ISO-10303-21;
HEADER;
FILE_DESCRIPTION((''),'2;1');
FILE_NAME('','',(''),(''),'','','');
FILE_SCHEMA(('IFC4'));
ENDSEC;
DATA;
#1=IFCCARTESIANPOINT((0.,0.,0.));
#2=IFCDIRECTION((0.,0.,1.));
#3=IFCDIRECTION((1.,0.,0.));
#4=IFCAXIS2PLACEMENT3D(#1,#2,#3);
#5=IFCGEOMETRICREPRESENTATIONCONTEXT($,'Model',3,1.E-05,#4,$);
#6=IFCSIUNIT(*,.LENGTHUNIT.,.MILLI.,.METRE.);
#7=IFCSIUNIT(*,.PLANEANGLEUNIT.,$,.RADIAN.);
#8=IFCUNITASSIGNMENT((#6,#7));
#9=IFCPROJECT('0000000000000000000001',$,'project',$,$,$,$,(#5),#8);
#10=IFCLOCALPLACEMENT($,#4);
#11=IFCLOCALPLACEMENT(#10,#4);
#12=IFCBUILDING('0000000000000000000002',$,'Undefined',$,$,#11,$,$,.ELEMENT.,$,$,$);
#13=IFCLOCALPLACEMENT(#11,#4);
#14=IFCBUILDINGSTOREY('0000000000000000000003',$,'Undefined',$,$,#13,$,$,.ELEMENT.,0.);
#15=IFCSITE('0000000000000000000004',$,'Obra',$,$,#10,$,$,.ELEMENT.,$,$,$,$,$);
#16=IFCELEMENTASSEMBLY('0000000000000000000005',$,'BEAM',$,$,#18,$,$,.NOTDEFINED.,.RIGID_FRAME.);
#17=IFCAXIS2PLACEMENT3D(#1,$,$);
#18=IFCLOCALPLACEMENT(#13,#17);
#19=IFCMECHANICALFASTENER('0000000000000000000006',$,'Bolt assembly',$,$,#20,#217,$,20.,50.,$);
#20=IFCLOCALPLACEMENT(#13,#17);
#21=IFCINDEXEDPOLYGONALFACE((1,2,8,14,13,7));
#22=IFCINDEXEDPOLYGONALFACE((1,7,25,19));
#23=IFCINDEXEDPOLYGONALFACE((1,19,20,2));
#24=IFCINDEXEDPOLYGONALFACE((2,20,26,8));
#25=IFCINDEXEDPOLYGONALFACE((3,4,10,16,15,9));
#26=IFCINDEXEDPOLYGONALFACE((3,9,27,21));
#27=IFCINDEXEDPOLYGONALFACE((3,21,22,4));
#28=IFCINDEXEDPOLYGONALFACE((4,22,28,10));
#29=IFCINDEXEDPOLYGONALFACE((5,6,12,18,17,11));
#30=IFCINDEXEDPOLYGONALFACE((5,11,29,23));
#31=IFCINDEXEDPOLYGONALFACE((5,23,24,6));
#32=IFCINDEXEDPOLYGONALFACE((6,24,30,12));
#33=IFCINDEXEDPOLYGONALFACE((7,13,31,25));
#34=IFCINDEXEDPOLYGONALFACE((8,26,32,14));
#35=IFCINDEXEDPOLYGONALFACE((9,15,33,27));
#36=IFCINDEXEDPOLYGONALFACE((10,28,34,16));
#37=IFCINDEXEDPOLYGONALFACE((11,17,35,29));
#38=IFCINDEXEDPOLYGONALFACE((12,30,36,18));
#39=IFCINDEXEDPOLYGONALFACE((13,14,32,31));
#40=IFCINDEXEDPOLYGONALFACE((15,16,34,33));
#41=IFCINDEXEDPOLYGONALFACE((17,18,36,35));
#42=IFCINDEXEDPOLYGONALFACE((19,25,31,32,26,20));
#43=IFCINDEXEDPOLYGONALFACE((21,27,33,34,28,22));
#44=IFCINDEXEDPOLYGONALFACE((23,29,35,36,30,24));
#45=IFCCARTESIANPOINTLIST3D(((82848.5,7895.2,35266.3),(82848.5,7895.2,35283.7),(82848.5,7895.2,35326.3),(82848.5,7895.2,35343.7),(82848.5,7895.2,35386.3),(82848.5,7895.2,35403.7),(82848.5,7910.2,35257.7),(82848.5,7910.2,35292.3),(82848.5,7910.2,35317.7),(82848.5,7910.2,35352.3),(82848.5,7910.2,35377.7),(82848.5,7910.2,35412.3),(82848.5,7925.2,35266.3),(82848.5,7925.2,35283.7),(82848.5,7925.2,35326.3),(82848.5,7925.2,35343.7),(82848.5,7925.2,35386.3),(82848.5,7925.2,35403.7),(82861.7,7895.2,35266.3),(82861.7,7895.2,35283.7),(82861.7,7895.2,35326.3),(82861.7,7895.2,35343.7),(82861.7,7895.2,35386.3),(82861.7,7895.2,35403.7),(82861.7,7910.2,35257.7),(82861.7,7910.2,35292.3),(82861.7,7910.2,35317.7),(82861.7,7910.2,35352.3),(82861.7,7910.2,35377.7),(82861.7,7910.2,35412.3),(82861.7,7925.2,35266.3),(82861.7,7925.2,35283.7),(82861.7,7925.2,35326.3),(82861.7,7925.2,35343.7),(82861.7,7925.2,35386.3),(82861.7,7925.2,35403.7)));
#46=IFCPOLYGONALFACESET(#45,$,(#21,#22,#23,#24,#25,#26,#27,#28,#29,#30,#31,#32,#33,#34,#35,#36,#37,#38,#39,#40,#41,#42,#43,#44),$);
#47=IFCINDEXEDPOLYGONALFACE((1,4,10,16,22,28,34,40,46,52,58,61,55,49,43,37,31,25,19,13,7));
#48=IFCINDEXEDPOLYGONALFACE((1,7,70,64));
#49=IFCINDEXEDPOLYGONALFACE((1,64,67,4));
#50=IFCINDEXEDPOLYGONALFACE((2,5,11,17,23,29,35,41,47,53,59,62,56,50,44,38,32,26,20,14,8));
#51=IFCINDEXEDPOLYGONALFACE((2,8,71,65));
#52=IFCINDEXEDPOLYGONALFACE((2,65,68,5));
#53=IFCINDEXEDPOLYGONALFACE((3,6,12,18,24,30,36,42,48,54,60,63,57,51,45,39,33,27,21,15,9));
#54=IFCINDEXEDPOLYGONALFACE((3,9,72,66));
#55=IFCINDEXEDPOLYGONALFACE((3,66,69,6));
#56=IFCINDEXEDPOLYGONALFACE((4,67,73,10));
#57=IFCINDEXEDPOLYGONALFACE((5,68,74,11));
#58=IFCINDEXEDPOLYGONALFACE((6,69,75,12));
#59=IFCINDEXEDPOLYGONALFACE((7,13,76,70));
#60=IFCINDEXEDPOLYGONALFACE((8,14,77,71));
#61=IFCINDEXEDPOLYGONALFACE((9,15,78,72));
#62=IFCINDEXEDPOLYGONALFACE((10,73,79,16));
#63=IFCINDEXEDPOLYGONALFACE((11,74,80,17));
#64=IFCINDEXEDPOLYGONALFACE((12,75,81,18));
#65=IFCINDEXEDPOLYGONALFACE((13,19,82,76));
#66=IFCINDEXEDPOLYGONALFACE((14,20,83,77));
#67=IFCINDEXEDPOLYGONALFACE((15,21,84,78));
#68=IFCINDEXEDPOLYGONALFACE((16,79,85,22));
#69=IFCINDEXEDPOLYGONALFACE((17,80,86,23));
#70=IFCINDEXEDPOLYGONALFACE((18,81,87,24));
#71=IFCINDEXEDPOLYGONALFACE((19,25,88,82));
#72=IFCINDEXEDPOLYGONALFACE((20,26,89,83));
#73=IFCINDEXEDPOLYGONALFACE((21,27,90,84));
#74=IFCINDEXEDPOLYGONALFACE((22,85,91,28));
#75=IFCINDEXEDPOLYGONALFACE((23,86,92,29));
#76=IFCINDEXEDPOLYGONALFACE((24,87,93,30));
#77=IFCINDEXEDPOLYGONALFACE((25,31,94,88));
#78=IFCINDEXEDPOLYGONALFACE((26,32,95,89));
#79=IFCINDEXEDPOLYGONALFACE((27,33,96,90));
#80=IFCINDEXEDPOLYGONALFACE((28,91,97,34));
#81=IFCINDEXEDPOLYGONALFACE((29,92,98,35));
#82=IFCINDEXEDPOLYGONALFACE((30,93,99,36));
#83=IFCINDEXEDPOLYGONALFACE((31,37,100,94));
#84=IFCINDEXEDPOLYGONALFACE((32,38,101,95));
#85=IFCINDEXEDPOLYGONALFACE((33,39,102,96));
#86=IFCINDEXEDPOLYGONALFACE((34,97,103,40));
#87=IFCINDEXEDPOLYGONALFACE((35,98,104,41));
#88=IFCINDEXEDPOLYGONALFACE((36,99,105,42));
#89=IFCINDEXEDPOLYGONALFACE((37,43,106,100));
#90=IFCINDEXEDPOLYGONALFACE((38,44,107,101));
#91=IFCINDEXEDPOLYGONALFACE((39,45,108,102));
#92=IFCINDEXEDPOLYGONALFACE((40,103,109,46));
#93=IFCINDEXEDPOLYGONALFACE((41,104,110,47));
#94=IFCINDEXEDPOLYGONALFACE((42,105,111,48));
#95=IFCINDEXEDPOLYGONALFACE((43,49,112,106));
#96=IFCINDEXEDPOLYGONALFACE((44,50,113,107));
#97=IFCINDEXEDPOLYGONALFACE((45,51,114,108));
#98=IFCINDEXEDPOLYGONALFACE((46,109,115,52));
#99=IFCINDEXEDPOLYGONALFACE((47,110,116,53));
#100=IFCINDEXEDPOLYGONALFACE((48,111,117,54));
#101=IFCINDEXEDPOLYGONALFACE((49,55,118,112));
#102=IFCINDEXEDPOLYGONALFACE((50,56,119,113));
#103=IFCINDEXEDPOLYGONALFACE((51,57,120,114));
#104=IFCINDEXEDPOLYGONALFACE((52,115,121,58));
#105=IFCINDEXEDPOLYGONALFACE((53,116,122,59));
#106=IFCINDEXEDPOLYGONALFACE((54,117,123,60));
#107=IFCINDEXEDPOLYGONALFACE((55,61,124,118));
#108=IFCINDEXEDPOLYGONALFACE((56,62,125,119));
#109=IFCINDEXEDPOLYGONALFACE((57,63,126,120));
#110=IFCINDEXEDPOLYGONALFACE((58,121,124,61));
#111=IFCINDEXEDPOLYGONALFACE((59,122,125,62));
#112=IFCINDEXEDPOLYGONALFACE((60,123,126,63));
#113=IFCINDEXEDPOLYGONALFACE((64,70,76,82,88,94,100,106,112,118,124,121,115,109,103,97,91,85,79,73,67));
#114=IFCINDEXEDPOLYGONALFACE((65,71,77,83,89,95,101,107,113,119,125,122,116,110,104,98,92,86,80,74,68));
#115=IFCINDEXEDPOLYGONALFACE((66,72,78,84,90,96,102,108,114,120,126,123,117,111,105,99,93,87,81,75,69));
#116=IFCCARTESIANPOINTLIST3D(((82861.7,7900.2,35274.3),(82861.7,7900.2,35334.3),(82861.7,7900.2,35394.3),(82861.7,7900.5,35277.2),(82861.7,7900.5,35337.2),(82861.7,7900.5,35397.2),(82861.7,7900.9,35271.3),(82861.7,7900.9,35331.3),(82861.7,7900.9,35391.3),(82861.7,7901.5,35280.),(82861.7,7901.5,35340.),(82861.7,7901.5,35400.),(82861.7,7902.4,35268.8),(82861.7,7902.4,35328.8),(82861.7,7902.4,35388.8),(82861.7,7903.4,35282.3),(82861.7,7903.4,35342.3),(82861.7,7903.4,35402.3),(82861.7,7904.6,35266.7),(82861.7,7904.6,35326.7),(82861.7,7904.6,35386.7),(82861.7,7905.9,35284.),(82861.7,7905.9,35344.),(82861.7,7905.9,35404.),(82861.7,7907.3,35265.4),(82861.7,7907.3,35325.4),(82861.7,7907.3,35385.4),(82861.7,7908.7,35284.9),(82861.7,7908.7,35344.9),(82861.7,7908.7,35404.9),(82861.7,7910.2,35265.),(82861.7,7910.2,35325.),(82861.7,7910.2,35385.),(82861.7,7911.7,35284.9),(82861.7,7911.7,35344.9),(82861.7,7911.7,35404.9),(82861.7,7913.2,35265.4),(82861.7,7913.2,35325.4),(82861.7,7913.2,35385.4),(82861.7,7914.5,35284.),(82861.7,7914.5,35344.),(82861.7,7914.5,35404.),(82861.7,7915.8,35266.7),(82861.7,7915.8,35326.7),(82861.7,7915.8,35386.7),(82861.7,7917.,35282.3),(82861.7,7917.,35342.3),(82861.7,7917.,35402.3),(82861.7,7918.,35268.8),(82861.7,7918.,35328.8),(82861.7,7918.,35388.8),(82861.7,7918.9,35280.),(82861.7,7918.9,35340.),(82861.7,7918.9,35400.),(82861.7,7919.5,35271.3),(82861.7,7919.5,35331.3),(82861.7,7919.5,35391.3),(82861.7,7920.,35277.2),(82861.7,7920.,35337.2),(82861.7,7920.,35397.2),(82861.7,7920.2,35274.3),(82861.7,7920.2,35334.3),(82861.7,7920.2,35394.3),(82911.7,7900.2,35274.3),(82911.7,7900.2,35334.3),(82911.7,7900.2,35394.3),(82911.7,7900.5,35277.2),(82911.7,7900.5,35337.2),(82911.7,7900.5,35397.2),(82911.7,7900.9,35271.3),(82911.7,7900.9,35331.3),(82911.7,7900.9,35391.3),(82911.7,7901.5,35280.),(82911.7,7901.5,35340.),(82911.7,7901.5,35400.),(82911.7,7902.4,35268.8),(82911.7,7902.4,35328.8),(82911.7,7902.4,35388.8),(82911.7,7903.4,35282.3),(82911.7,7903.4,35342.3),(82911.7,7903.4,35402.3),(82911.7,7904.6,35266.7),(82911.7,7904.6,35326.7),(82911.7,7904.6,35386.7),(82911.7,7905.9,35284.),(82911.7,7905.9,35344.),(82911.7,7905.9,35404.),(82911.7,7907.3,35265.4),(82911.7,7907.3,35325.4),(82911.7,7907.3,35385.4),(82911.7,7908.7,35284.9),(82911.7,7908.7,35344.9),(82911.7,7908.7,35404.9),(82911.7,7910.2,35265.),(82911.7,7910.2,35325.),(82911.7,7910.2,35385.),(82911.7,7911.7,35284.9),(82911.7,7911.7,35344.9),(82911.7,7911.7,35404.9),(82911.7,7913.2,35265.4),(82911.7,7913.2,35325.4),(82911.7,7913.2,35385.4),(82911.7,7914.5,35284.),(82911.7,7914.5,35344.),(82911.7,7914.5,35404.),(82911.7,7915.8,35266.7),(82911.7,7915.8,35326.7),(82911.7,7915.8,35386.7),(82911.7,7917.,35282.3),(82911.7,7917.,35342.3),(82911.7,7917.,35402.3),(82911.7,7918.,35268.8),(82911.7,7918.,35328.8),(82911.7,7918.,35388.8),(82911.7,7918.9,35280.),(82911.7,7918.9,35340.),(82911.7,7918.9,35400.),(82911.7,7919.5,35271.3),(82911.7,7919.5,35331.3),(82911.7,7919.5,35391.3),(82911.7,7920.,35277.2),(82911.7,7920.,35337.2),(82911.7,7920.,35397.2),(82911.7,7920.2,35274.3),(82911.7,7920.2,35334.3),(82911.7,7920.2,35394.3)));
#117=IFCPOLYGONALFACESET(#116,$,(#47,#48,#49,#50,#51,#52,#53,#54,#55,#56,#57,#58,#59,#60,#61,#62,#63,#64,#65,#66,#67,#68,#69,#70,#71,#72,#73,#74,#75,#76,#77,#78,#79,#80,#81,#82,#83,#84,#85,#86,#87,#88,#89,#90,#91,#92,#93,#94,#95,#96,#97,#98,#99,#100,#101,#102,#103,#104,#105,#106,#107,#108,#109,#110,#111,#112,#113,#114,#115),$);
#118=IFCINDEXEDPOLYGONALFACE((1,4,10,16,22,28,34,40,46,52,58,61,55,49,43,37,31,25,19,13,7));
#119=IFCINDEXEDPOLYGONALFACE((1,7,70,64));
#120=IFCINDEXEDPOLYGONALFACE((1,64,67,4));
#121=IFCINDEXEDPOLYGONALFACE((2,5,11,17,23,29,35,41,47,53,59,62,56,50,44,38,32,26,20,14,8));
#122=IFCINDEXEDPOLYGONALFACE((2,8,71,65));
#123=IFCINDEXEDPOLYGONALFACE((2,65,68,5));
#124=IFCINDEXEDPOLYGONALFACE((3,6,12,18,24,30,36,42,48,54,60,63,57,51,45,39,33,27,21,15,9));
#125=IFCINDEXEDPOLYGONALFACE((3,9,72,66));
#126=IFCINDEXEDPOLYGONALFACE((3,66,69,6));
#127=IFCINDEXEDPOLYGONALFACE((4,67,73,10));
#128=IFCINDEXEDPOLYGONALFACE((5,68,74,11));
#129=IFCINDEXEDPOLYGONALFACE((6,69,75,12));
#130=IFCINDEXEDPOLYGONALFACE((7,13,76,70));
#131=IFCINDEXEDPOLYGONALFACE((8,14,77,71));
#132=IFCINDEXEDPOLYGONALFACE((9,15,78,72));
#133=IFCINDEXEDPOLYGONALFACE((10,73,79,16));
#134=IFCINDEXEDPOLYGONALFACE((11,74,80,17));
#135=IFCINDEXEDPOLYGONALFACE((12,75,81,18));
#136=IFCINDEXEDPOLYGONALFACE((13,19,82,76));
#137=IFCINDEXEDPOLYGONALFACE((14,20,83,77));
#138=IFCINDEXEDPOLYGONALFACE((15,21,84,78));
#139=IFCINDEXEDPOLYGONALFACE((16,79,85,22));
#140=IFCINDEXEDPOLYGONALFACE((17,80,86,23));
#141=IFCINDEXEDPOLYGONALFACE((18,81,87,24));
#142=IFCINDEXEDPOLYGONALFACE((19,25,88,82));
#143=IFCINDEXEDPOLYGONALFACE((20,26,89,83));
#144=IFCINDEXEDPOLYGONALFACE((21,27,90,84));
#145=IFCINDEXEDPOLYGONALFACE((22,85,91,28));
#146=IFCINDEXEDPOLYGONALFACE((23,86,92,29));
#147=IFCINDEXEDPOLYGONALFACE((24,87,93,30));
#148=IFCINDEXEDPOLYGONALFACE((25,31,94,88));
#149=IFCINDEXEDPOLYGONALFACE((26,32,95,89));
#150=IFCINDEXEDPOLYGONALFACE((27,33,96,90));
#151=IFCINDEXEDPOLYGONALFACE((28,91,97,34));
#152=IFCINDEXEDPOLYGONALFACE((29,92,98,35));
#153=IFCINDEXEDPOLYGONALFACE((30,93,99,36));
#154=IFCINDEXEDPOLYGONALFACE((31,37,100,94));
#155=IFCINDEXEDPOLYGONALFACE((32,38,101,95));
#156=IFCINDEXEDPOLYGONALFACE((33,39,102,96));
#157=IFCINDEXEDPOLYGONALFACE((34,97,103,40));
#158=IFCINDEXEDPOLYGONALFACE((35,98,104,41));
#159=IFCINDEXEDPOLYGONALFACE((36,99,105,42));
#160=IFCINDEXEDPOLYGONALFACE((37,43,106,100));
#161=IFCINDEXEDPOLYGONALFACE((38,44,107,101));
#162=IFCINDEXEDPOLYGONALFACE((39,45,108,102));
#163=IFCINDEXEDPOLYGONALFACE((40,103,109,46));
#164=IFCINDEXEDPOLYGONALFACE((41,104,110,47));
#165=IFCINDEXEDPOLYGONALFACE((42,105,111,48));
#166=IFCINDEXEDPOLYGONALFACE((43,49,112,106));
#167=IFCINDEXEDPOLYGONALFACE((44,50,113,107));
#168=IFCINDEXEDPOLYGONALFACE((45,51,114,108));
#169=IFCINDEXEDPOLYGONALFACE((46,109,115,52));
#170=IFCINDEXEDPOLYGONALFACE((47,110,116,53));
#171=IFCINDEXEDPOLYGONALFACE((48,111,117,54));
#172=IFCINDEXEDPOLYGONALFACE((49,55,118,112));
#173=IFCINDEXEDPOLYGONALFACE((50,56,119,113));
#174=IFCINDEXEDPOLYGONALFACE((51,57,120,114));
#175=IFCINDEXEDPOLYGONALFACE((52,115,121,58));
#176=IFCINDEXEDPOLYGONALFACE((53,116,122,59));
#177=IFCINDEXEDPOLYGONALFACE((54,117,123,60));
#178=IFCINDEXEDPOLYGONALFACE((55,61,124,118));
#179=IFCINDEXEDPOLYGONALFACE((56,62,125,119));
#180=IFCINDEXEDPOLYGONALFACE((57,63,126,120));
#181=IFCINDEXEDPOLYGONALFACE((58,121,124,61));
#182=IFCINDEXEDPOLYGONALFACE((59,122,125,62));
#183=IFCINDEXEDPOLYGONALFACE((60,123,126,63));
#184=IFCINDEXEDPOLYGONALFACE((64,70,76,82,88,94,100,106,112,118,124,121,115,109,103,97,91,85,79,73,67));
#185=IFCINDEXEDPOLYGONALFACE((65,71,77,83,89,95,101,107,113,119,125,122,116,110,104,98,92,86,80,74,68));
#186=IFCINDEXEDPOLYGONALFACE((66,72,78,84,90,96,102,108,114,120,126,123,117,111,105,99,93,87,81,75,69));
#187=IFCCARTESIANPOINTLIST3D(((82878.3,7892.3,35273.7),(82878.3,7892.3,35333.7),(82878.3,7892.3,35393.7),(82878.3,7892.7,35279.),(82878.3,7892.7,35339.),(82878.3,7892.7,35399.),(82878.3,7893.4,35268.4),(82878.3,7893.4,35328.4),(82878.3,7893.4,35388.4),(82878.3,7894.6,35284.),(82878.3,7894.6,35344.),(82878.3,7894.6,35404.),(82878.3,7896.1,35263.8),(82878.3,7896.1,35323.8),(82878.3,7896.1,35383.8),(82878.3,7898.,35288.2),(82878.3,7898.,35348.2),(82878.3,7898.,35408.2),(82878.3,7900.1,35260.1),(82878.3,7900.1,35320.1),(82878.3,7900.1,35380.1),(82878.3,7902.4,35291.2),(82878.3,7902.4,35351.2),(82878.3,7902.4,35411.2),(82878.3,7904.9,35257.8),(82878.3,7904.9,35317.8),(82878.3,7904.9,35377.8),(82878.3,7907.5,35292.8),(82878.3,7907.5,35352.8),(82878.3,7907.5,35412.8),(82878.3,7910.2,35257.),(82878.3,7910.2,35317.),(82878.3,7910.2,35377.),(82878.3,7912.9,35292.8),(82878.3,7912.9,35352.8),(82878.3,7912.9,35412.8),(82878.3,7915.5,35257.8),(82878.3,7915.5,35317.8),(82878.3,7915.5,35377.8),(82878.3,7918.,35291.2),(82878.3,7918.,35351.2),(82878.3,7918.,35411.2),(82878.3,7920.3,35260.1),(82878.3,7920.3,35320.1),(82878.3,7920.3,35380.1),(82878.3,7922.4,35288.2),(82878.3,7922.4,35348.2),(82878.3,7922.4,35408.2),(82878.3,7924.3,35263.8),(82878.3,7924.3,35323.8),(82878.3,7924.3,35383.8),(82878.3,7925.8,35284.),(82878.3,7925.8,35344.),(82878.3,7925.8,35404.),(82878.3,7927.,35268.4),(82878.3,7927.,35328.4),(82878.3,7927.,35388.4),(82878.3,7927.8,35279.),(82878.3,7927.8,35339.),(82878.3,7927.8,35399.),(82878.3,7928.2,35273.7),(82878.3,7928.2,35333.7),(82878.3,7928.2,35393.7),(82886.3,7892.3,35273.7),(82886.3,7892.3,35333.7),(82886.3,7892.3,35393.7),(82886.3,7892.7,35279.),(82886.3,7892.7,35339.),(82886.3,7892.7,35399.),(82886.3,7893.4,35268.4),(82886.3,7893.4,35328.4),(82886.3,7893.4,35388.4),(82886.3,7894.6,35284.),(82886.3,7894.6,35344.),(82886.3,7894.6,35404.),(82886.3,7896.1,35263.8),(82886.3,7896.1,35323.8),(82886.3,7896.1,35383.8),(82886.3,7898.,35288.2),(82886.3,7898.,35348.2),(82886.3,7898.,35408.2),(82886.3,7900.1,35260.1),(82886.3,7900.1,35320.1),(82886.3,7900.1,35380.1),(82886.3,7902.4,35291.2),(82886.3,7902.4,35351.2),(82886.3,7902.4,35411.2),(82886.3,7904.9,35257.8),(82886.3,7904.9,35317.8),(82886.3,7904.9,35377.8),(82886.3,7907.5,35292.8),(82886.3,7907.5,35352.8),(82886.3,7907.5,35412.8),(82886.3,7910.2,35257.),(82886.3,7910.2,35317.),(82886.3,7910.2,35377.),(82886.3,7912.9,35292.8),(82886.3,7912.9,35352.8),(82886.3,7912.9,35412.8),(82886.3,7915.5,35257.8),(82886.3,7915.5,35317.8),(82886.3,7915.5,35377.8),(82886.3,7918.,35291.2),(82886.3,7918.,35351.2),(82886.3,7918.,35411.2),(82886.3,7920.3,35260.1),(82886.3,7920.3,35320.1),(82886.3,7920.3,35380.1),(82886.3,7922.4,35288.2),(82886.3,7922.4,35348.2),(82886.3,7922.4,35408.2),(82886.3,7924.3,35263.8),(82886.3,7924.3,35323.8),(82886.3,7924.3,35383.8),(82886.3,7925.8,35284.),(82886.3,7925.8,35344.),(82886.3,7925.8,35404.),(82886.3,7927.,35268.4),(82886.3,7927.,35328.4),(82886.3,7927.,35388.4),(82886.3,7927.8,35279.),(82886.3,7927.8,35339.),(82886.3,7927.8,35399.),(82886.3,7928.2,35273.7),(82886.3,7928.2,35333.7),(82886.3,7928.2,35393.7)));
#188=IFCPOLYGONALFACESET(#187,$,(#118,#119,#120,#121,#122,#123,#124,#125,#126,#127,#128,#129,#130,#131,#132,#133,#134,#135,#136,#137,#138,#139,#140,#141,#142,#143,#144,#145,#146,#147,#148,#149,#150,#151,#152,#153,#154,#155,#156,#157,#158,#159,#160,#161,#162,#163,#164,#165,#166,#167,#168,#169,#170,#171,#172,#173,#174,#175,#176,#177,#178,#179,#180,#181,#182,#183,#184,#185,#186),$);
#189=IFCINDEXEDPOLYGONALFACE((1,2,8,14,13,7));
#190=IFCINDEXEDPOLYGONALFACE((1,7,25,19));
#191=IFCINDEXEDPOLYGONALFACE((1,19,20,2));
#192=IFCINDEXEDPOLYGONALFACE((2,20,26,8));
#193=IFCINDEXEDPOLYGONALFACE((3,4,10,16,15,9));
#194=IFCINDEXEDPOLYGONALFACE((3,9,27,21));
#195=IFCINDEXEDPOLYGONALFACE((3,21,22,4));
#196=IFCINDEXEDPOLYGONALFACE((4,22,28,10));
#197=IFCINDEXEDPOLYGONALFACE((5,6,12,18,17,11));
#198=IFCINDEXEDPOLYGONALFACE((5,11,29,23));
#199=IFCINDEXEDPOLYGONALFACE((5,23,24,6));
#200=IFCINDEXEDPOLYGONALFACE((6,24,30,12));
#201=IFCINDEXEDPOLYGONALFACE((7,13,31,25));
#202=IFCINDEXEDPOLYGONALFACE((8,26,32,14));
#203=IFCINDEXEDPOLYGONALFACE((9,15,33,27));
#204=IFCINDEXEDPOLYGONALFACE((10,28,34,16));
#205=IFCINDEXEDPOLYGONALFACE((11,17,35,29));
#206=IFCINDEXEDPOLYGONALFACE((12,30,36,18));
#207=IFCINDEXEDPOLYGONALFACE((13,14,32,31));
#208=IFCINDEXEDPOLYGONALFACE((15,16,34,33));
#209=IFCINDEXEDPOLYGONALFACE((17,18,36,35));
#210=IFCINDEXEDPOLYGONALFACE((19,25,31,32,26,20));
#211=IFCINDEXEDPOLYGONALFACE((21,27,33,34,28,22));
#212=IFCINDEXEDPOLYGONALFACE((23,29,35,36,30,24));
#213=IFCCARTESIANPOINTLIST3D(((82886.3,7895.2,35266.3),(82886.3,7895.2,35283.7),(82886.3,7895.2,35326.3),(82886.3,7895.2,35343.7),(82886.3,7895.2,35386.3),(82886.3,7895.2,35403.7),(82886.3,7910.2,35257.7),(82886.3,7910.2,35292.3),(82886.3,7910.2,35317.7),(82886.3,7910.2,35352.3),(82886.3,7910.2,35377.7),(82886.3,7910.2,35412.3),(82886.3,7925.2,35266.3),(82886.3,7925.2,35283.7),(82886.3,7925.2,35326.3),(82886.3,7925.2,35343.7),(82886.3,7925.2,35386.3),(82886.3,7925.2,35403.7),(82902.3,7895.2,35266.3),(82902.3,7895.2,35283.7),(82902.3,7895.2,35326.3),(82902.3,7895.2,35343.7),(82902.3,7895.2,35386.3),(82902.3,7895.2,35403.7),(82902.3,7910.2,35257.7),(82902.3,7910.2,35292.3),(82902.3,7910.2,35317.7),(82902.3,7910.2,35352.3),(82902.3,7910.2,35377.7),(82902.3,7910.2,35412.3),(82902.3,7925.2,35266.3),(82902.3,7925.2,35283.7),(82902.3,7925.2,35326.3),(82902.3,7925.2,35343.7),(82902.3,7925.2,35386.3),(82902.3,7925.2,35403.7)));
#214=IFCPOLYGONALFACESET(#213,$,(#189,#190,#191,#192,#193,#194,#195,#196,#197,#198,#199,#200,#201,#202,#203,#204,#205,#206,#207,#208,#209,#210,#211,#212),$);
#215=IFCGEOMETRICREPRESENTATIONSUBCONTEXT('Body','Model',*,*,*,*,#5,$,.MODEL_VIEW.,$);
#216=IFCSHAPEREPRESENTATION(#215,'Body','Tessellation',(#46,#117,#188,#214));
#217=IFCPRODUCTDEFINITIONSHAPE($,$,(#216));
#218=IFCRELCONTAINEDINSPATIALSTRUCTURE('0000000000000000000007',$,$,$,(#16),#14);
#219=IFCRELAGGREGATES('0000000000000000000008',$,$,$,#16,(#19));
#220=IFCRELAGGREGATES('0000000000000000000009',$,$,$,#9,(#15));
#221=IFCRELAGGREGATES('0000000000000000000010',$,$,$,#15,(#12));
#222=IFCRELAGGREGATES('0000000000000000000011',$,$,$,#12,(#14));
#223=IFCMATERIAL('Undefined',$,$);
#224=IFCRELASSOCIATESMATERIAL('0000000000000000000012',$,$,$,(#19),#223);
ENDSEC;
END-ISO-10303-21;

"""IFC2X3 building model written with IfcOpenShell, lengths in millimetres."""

from ifc_helpers import new_model, si_unit, frame, origin_with_axes, origin_2d_with_axis, place, context, subcontext, project, spatial, polyline, circle, outline, extrude, source, transform, mapped, material, element, aggregate, save


model = new_model("IFC2X3")

# Units and contexts
model_context = context("Model", 3, precision=1e-05, world=origin_with_axes())
body_context = subcontext(model_context, "Body", "Model", "MODEL_VIEW")
ifc_project = project(units=[si_unit("LENGTHUNIT", "METRE", prefix="MILLI"), si_unit("PLANEANGLEUNIT", "RADIAN")], contexts=[model_context])

# Site, building, storey
site_placement = place(None, origin_with_axes())
site = spatial("IfcSite", under=ifc_project, at=site_placement, Name="Obra", CompositionType="ELEMENT")
building_placement = place(site_placement, origin_with_axes())
building = spatial("IfcBuilding", under=site, at=building_placement, Name="Undefined", CompositionType="ELEMENT")
storey_placement = place(building_placement, origin_with_axes())
storey = spatial("IfcBuildingStorey", under=building, at=storey_placement, Name="Undefined", CompositionType="ELEMENT", Elevation=0.0)

# Element assembly
assembly_1_placement = place(storey_placement, origin_with_axes())
assembly_1 = element("IfcElementAssembly", 1, at=assembly_1_placement, inside=storey, Name="BEAM", AssemblyPlace="NOTDEFINED", PredefinedType="RIGID_FRAME")

# Shared definitions
ifc_material_1 = material(Name="Undefined")

# Mechanical fastener
shared_shape_1 = source(origin_with_axes(), body_context, "Body", "SweptSolid", [
    extrude(outline(polyline([(17.3, 0.0), (8.7, 15.0), (-8.7, 15.0), (-17.3, 0.0), (-8.7, -15.0), (8.7, -15.0), (17.3, 0.0)])), frame((0.0, -26.5, 0.0), z_axis=(0.0, 1.0, 0.0), x_axis=(1.0, 0.0, 0.0)), (0.0, 0.0, 1.0), 13.2),
    extrude(circle(Radius=10.0, at=origin_2d_with_axis()), frame((0.0, -13.3, 0.0), z_axis=(0.0, 1.0, 0.0), x_axis=(1.0, 0.0, 0.0)), (0.0, 0.0, 1.0), 50.0),
    extrude(circle(Radius=18.0, at=origin_2d_with_axis()), frame((0.0, 3.3, 0.0), z_axis=(0.0, 1.0, 0.0), x_axis=(1.0, 0.0, 0.0)), (0.0, 0.0, 1.0), 8.0),
    extrude(outline(polyline([(17.3, 0.0), (8.7, 15.0), (-8.7, 15.0), (-17.3, 0.0), (-8.7, -15.0), (8.7, -15.0), (17.3, 0.0)])), frame((0.0, 11.3, 0.0), z_axis=(0.0, 1.0, 0.0), x_axis=(1.0, 0.0, 0.0)), (0.0, 0.0, 1.0), 16.0),
])
mechanical_fastener_1_placement = place(assembly_1_placement, frame((82875.0, 7960.2, 35435.0), z_axis=(0.0, -1.0, 0.0), x_axis=(0.0, 0.0, -1.0)))
mechanical_fastener_1 = element("IfcMechanicalFastener", 2, at=mechanical_fastener_1_placement, material=ifc_material_1, Name="Bolt assembly", NominalDiameter=20.0, NominalLength=50.0, context=body_context, shape_type="MappedRepresentation", body=[
    mapped(shared_shape_1, transform((40.0, 0.0, 50.0))),
    mapped(shared_shape_1, transform((100.0, 0.0, 50.0))),
    mapped(shared_shape_1, transform((160.0, 0.0, 50.0))),
])
aggregate(assembly_1, [mechanical_fastener_1])

save(model, "model.ifc")
